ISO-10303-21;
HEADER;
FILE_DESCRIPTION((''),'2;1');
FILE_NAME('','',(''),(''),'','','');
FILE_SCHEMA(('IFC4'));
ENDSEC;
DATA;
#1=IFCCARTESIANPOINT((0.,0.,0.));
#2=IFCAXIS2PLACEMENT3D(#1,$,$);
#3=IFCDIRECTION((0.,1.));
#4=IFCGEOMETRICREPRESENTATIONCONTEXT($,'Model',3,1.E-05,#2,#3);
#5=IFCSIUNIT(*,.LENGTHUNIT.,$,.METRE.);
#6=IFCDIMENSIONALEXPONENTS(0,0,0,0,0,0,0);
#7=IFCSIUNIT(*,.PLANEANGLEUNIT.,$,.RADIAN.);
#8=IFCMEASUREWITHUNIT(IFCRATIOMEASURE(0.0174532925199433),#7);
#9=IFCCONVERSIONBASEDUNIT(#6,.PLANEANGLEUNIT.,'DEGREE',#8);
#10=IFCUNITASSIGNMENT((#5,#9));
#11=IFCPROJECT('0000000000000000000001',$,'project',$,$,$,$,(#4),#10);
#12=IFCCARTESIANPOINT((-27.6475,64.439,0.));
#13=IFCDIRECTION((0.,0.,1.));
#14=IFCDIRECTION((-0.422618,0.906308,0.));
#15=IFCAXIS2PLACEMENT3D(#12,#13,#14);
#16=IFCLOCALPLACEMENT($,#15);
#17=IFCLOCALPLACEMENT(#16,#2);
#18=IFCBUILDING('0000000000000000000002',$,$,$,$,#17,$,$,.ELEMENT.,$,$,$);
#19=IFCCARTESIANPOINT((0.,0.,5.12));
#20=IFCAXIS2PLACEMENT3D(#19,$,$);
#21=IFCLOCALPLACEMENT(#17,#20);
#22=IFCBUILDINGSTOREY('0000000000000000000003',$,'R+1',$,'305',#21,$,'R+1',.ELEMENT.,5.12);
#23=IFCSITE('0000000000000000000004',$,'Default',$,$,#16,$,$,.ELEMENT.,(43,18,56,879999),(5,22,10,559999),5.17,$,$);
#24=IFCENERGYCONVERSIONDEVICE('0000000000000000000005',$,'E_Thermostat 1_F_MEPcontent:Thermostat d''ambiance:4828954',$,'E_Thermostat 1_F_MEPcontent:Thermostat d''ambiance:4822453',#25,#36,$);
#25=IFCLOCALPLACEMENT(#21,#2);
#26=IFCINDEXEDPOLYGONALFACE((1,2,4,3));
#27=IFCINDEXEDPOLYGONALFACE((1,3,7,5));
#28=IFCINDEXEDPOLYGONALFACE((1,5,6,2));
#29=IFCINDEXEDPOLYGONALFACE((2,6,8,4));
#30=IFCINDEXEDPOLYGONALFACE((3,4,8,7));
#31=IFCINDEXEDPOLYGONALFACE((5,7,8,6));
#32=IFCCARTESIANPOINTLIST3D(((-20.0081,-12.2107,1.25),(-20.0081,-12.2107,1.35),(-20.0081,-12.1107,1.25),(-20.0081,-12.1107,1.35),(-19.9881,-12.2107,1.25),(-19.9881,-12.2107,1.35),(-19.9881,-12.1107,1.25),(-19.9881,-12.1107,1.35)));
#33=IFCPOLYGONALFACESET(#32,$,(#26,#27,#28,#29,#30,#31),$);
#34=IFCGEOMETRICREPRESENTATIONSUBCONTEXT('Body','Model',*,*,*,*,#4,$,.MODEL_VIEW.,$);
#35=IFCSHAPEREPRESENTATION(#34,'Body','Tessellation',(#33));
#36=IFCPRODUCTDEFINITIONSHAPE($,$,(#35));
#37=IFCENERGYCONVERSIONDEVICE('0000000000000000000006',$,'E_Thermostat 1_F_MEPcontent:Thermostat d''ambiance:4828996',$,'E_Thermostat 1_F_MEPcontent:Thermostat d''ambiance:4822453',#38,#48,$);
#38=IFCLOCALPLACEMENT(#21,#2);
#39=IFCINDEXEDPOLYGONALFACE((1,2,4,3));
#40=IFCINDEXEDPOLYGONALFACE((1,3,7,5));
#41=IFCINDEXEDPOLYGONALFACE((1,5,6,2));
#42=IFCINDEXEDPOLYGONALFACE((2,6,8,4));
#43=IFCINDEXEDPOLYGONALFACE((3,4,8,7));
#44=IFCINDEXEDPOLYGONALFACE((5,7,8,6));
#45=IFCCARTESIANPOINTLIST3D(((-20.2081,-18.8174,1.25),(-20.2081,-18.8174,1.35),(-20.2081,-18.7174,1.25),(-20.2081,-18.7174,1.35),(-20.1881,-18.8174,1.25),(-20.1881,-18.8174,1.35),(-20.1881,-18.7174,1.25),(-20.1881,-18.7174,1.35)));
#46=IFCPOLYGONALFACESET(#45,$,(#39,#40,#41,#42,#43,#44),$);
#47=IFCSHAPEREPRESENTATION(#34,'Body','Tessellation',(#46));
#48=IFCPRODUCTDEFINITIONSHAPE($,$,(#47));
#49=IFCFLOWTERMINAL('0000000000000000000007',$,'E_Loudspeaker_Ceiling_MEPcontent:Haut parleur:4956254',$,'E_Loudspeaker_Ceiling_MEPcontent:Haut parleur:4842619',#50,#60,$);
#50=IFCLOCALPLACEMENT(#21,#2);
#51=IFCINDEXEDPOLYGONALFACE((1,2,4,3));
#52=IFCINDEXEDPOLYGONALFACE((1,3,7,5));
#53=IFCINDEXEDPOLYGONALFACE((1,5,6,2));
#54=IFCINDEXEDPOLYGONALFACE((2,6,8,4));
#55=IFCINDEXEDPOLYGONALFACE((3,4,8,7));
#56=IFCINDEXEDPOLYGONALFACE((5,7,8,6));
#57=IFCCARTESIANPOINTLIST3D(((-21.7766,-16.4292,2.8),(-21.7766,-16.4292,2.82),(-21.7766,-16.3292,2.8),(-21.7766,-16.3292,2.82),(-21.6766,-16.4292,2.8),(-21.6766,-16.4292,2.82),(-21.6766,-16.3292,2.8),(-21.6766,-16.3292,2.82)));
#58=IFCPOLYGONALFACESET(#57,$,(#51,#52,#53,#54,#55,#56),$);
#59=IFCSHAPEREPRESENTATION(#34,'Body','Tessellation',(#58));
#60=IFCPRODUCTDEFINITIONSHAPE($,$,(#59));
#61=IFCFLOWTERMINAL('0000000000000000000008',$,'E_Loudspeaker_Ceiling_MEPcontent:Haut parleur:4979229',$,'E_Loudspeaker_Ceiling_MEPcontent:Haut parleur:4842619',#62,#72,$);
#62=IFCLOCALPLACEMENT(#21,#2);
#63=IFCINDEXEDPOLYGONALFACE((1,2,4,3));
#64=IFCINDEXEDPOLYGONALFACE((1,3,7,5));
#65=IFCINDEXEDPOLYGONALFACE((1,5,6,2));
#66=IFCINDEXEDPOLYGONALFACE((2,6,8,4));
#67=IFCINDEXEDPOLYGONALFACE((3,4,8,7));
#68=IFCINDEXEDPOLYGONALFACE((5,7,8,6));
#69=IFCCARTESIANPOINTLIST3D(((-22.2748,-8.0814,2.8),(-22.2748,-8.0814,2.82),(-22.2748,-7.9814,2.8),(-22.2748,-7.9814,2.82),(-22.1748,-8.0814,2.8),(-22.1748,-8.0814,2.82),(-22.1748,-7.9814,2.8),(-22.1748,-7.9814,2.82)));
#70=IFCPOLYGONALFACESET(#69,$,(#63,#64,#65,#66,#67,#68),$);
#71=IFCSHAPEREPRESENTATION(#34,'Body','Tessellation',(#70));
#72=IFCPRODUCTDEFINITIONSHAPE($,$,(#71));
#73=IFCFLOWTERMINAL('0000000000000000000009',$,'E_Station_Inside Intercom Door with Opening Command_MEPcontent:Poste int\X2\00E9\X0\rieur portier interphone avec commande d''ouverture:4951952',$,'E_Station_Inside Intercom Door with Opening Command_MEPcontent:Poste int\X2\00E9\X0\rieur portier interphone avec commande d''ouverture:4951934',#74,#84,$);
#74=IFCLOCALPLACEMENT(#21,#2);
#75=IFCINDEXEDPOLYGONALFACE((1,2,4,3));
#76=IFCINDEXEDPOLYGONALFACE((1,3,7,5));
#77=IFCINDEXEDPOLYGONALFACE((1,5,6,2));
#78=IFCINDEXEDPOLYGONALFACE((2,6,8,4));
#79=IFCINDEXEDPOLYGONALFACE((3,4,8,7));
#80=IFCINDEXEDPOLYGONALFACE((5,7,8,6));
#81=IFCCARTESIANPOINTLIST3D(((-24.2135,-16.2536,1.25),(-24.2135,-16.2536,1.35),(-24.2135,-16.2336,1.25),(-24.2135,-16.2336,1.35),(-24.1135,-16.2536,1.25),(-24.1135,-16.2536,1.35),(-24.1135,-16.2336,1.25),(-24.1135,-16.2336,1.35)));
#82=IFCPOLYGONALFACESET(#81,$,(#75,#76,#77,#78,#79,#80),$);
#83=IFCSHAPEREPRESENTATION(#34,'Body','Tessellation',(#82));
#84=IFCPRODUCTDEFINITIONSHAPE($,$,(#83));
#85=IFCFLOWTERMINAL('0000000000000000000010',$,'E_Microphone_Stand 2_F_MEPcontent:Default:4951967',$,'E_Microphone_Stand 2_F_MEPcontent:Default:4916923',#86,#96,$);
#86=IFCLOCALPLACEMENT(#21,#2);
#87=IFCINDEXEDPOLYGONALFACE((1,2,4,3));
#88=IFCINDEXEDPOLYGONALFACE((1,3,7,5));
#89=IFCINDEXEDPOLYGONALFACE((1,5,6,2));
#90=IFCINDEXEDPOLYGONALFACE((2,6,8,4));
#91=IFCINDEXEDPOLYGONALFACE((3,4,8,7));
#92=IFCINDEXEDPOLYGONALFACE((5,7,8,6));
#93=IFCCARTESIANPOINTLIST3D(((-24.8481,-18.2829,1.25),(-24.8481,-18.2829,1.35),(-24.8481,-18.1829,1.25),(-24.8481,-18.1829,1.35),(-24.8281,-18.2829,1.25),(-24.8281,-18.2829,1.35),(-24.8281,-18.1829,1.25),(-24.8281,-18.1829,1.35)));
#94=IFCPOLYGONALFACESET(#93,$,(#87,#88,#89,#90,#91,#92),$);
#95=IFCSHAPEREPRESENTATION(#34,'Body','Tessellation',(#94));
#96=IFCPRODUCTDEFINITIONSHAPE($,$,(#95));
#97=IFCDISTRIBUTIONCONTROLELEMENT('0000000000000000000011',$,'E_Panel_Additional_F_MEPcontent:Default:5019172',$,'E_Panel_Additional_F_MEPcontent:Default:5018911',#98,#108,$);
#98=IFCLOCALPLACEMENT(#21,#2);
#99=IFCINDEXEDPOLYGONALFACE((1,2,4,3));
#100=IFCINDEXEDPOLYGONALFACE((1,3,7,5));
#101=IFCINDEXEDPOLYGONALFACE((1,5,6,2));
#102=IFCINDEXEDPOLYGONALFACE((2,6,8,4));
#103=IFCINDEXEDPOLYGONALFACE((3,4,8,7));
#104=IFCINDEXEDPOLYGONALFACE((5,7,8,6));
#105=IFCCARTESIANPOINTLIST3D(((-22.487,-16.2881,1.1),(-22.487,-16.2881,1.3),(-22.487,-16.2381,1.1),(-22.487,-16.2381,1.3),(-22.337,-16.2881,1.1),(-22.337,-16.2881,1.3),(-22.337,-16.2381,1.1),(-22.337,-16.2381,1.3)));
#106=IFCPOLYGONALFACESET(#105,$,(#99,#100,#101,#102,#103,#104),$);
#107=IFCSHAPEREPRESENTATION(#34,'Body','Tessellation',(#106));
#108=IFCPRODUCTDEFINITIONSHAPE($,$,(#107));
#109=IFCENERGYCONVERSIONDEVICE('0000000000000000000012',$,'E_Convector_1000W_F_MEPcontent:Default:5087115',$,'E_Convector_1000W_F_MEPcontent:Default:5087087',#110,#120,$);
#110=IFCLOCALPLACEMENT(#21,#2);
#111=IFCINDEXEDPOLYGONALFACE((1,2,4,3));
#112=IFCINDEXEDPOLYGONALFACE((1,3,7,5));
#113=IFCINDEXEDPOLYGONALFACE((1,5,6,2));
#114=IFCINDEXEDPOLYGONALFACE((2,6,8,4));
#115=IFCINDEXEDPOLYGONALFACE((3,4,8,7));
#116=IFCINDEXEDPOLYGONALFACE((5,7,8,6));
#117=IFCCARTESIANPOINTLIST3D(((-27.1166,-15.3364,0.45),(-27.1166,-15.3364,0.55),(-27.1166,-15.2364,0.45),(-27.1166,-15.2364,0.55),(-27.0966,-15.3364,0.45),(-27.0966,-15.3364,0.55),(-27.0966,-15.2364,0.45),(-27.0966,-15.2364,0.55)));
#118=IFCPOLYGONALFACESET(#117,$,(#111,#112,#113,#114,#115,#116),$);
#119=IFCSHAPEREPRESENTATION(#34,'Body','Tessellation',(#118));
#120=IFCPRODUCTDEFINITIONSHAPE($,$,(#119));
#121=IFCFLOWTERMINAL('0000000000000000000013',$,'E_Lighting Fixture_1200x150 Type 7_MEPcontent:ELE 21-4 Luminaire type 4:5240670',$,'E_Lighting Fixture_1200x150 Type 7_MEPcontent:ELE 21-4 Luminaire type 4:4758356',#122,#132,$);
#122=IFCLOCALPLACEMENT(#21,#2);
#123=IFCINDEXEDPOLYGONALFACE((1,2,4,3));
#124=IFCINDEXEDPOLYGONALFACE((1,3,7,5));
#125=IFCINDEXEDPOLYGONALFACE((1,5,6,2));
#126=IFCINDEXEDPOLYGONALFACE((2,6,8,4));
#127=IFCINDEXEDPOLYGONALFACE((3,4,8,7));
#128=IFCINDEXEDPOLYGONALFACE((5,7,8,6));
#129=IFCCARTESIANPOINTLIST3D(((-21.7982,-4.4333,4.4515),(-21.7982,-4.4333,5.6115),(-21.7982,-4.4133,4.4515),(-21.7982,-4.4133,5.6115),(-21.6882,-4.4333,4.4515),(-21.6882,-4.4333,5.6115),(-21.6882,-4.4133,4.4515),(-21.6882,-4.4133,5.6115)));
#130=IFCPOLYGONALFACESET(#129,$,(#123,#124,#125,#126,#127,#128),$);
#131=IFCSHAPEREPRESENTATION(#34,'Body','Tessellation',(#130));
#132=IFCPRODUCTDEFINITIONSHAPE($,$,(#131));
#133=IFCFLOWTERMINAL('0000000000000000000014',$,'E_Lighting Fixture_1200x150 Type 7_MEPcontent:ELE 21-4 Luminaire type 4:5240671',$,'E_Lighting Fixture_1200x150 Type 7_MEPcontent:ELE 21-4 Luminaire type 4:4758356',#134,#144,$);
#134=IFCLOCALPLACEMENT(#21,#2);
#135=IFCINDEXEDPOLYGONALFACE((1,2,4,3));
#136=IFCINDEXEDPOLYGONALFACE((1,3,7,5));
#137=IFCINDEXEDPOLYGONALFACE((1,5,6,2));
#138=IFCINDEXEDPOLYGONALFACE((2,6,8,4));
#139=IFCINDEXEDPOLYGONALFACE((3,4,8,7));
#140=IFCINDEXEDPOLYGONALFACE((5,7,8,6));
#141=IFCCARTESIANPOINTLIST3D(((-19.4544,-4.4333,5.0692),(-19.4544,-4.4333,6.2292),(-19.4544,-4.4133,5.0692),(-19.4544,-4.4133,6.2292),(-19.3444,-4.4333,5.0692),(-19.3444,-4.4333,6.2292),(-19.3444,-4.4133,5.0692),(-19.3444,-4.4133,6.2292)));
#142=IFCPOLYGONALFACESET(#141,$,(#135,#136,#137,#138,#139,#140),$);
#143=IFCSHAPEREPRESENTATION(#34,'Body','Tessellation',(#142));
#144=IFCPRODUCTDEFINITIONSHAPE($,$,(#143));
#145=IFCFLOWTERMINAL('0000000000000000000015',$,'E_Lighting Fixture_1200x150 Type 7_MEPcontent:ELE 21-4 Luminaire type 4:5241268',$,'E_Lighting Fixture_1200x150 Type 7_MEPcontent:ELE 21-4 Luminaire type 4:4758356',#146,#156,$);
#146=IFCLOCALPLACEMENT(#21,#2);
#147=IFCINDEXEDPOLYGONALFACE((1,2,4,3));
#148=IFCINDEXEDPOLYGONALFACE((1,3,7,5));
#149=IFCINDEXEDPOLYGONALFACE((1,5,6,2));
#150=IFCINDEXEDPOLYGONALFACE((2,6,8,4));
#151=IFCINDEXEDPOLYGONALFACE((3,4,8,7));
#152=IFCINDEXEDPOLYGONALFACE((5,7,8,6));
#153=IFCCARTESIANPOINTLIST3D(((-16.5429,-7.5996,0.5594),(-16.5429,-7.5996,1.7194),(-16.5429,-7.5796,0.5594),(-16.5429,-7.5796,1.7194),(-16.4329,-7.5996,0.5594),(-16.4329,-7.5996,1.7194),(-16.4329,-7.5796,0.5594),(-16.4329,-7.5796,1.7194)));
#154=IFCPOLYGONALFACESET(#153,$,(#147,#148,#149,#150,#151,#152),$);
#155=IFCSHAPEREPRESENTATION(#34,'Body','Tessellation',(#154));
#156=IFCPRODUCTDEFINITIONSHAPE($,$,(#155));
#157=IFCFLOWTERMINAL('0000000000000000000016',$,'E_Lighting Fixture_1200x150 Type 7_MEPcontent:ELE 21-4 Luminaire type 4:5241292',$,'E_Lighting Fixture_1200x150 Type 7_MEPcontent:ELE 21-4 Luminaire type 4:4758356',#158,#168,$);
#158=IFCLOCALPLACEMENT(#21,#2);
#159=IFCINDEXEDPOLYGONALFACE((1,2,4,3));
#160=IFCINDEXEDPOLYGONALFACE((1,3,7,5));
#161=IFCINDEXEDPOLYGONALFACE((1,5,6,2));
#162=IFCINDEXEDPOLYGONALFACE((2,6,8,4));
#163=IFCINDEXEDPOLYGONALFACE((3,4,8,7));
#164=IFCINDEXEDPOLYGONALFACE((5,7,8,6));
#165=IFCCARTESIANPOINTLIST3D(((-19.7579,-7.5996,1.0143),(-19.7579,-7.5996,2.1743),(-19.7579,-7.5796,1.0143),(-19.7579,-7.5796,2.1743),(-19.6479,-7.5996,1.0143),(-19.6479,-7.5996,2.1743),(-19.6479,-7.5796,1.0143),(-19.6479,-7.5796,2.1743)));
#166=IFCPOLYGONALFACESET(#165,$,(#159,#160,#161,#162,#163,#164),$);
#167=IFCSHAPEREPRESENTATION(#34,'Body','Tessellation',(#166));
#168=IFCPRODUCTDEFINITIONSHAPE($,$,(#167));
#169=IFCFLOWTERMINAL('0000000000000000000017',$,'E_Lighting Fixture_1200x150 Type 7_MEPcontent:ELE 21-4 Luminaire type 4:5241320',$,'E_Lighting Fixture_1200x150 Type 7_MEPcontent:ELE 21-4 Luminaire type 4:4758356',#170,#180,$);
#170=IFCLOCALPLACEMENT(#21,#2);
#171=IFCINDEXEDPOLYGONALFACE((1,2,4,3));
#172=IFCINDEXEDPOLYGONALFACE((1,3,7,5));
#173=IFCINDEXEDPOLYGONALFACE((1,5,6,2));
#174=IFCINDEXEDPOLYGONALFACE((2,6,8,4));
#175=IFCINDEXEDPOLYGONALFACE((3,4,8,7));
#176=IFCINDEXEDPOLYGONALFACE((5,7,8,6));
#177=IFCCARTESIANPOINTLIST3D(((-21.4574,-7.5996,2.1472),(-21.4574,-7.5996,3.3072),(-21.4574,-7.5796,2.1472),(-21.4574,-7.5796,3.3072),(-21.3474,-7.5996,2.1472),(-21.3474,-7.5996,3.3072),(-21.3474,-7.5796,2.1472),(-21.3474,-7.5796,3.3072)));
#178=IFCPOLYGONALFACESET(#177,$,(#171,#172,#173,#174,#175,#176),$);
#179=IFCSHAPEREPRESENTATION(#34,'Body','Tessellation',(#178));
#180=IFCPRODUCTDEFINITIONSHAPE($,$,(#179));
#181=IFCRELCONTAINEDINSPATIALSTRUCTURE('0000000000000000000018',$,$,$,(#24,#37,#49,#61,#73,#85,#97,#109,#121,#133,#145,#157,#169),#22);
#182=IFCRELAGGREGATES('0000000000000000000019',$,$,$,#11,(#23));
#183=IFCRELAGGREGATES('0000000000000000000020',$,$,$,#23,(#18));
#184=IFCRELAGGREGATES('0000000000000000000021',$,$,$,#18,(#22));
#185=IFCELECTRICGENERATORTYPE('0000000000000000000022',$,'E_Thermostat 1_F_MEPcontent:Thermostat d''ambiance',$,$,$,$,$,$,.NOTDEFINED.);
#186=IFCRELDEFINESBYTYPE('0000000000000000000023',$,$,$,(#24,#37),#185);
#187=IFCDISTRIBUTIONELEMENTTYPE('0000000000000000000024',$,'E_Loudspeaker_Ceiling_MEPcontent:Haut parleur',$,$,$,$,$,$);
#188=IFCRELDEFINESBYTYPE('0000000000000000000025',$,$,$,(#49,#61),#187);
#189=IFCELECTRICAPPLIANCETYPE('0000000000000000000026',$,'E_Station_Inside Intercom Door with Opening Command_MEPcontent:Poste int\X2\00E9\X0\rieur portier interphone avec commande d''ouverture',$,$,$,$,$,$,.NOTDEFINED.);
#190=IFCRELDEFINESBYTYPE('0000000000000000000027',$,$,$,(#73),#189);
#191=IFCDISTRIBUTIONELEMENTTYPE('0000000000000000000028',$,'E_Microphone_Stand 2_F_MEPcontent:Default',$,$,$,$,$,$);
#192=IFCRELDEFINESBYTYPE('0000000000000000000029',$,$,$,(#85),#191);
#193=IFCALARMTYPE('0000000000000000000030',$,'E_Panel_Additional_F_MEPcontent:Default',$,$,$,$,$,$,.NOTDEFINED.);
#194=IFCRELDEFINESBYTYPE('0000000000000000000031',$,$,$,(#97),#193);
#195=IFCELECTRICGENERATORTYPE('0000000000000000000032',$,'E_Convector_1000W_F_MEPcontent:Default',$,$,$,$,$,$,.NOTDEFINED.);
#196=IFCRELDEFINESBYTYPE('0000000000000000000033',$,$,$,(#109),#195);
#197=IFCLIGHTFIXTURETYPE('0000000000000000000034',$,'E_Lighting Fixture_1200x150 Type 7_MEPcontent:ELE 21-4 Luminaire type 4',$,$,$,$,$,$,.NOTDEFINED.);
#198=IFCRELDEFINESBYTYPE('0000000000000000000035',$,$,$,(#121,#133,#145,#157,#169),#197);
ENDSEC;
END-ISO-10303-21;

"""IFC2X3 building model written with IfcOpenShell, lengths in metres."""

from ifc_helpers import new_model, entity, si_unit, converted_unit, direction, frame, frame_2d, origin, origin_2d_with_axis, place, context, subcontext, project, spatial, rectangle, extrude, source, transform, mapped, type_object, type_shapes, element, save


model = new_model("IFC2X3")

# Units and contexts
model_context = context("Model", 3, precision=1e-05, world=origin(), true_north=direction((0.0, 1.0)))
body_context = subcontext(model_context, "Body", "Model", "MODEL_VIEW")
ifc_project = project(units=[si_unit("LENGTHUNIT", "METRE"), converted_unit("PLANEANGLEUNIT", "DEGREE", entity("IfcRatioMeasure", 0.0174532925199433), si_unit("PLANEANGLEUNIT", "RADIAN"), dimensions=[0, 0, 0, 0, 0, 0, 0])], contexts=[model_context])

# Site, building, storey
site_placement = place(None, frame((-27.6475, 64.439, 0.0), z_axis=(0.0, 0.0, 1.0), x_axis=(-0.422618, 0.906308, 0.0)))
site = spatial("IfcSite", under=ifc_project, at=site_placement, Name="Default", CompositionType="ELEMENT", RefLatitude=(43, 18, 56, 879999), RefLongitude=(5, 22, 10, 559999), RefElevation=5.17)
building_placement = place(site_placement, origin())
building = spatial("IfcBuilding", under=site, at=building_placement, CompositionType="ELEMENT")
storey_placement = place(building_placement, frame((0.0, 0.0, 5.12)))
storey = spatial("IfcBuildingStorey", under=building, at=storey_placement, Name="R+1", ObjectType="305", LongName="R+1", CompositionType="ELEMENT", Elevation=5.12)

# Energy conversion devices
electric_generator_type_1 = type_object("IfcElectricGeneratorType", Name="E_Thermostat 1_F_MEPcontent:Thermostat d'ambiance", PredefinedType="NOTDEFINED")
shared_shape_1 = source(origin(), body_context, "Body", "SweptSolid", [
    extrude(rectangle(XDim=0.1, YDim=0.1, at=origin_2d_with_axis()), frame((0.0, 0.0, 0.0), z_axis=(0.0, 0.0, 1.0), x_axis=(0.0, 1.0, 0.0)), (0.0, 0.0, 1.0), 0.02),
])
type_shapes(electric_generator_type_1, [shared_shape_1])
for number, where, z_axis, x_axis, name in (
    (1, (-20.0081, -12.1607, 1.3), (1.0, 0.0, 0.0), (0.0, 1.0, 0.0), "E_Thermostat 1_F_MEPcontent:Thermostat d'ambiance:4828954"),
    (2, (-20.1881, -18.7674, 1.3), (-1.0, 0.0, 0.0), (0.0, -1.0, 0.0), "E_Thermostat 1_F_MEPcontent:Thermostat d'ambiance:4828996"),
):
    element("IfcEnergyConversionDevice", number, at=place(storey_placement, frame(where, z_axis=z_axis, x_axis=x_axis)), inside=storey, type_object=electric_generator_type_1, Name=name, ObjectType="E_Thermostat 1_F_MEPcontent:Thermostat d'ambiance:4822453", context=body_context, shape_type="MappedRepresentation", body=[
        mapped(shared_shape_1, transform((0.0, 0.0, 0.0), scale=1.0)),
    ])

# Flow terminals
distribution_element_type_1 = type_object("IfcDistributionElementType", Name="E_Loudspeaker_Ceiling_MEPcontent:Haut parleur")
shared_shape_2 = source(origin(), body_context, "Body", "SweptSolid", [
    extrude(rectangle(XDim=0.1, YDim=0.1, at=origin_2d_with_axis()), frame((0.0, 0.0, 0.0), z_axis=(0.0, 0.0, 1.0), x_axis=(0.0, -1.0, 0.0)), (0.0, 0.0, 1.0), 0.02),
])
type_shapes(distribution_element_type_1, [shared_shape_2])
for number, where, z_axis, x_axis, name in (
    (3, (-21.7266, -16.3792, 2.8), (0.0, 0.0, 1.0), (-1.0, 0.0, 0.0), "E_Loudspeaker_Ceiling_MEPcontent:Haut parleur:4956254"),
    (4, (-22.2248, -8.0314, 2.8), (0.0, 0.0, 1.0), (-1.0, 0.0, 0.0), "E_Loudspeaker_Ceiling_MEPcontent:Haut parleur:4979229"),
):
    element("IfcFlowTerminal", number, at=place(storey_placement, frame(where, z_axis=z_axis, x_axis=x_axis)), inside=storey, type_object=distribution_element_type_1, Name=name, ObjectType="E_Loudspeaker_Ceiling_MEPcontent:Haut parleur:4842619", context=body_context, shape_type="MappedRepresentation", body=[
        mapped(shared_shape_2, transform((0.0, 0.0, 0.0), scale=1.0)),
    ])
electric_appliance_type = type_object("IfcElectricApplianceType", Name="E_Station_Inside Intercom Door with Opening Command_MEPcontent:Poste intérieur portier interphone avec commande d'ouverture", PredefinedType="NOTDEFINED")
shared_shape_3 = source(origin(), body_context, "Body", "SweptSolid", [
    extrude(rectangle(XDim=0.02, YDim=0.1, at=frame_2d((0.0, 0.0), x_axis=(1.0, 0.0))), frame((0.0, 0.01, -0.05), z_axis=(0.0, 0.0, 1.0), x_axis=(0.0, -1.0, 0.0)), (0.0, 0.0, 1.0), 0.1),
])
type_shapes(electric_appliance_type, [shared_shape_3])
flow_terminal_1_placement = place(storey_placement, frame((-24.1635, -16.2336, 1.3), z_axis=(0.0, 0.0, 1.0), x_axis=(-1.0, 0.0, 0.0)))
element("IfcFlowTerminal", 5, at=flow_terminal_1_placement, inside=storey, type_object=electric_appliance_type, Name="E_Station_Inside Intercom Door with Opening Command_MEPcontent:Poste intérieur portier interphone avec commande d'ouverture:4951952", ObjectType="E_Station_Inside Intercom Door with Opening Command_MEPcontent:Poste intérieur portier interphone avec commande d'ouverture:4951934", context=body_context, shape_type="MappedRepresentation", body=[
    mapped(shared_shape_3, transform((0.0, 0.0, 0.0), scale=1.0)),
])
distribution_element_type_2 = type_object("IfcDistributionElementType", Name="E_Microphone_Stand 2_F_MEPcontent:Default")
shared_shape_4 = source(origin(), body_context, "Body", "SweptSolid", [
    extrude(rectangle(XDim=0.1, YDim=0.1, at=origin_2d_with_axis()), frame((0.0, 0.0, 0.0), z_axis=(0.0, 0.0, 1.0), x_axis=(0.0, 1.0, 0.0)), (0.0, 0.0, 1.0), 0.02),
])
type_shapes(distribution_element_type_2, [shared_shape_4])
flow_terminal_2_placement = place(storey_placement, frame((-24.8481, -18.2329, 1.3), z_axis=(1.0, 0.0, 0.0), x_axis=(0.0, 1.0, 0.0)))
element("IfcFlowTerminal", 6, at=flow_terminal_2_placement, inside=storey, type_object=distribution_element_type_2, Name="E_Microphone_Stand 2_F_MEPcontent:Default:4951967", ObjectType="E_Microphone_Stand 2_F_MEPcontent:Default:4916923", context=body_context, shape_type="MappedRepresentation", body=[
    mapped(shared_shape_4, transform((0.0, 0.0, 0.0), scale=1.0)),
])

# Distribution control element
alarm_type_1 = type_object("IfcAlarmType", Name="E_Panel_Additional_F_MEPcontent:Default", PredefinedType="NOTDEFINED")
shared_shape_5 = source(origin(), body_context, "Body", "SweptSolid", [
    extrude(rectangle(XDim=0.2, YDim=0.15, at=origin_2d_with_axis()), frame((0.0, -0.1, 0.0), z_axis=(0.0, 0.0, 1.0), x_axis=(0.0, 1.0, 0.0)), (0.0, 0.0, 1.0), 0.05),
])
type_shapes(alarm_type_1, [shared_shape_5])
distribution_control_element_1_placement = place(storey_placement, frame((-22.412, -16.2381, 1.3), z_axis=(0.0, -1.0, 0.0), x_axis=(1.0, 0.0, 0.0)))
element("IfcDistributionControlElement", 7, at=distribution_control_element_1_placement, inside=storey, type_object=alarm_type_1, Name="E_Panel_Additional_F_MEPcontent:Default:5019172", ObjectType="E_Panel_Additional_F_MEPcontent:Default:5018911", context=body_context, shape_type="MappedRepresentation", body=[
    mapped(shared_shape_5, transform((0.0, 0.0, 0.0), scale=1.0)),
])

# Energy conversion device
electric_generator_type_2 = type_object("IfcElectricGeneratorType", Name="E_Convector_1000W_F_MEPcontent:Default", PredefinedType="NOTDEFINED")
shared_shape_6 = source(origin(), body_context, "Body", "SweptSolid", [
    extrude(rectangle(XDim=0.1, YDim=0.1, at=origin_2d_with_axis()), frame((0.0, 0.0, 0.0), z_axis=(0.0, 0.0, 1.0), x_axis=(0.0, 1.0, 0.0)), (0.0, 0.0, 1.0), 0.02),
])
type_shapes(electric_generator_type_2, [shared_shape_6])
energy_conversion_device_1_placement = place(storey_placement, frame((-27.1166, -15.2864, 0.5), z_axis=(1.0, 0.0, 0.0), x_axis=(0.0, 1.0, 0.0)))
element("IfcEnergyConversionDevice", 8, at=energy_conversion_device_1_placement, inside=storey, type_object=electric_generator_type_2, Name="E_Convector_1000W_F_MEPcontent:Default:5087115", ObjectType="E_Convector_1000W_F_MEPcontent:Default:5087087", context=body_context, shape_type="MappedRepresentation", body=[
    mapped(shared_shape_6, transform((0.0, 0.0, 0.0), scale=1.0)),
])

# Flow terminals
light_fixture_type_1 = type_object("IfcLightFixtureType", Name="E_Lighting Fixture_1200x150 Type 7_MEPcontent:ELE 21-4 Luminaire type 4", PredefinedType="NOTDEFINED")
shared_shape_7 = source(origin(), body_context, "Body", "SweptSolid", [
    extrude(rectangle(XDim=0.02, YDim=0.11, at=frame_2d((0.0, 0.0), x_axis=(1.0, 0.0))), frame((0.0, 0.01, -0.58), z_axis=(0.0, 0.0, 1.0), x_axis=(0.0, -1.0, 0.0)), (0.0, 0.0, 1.0), 1.16),
])
type_shapes(light_fixture_type_1, [shared_shape_7])
for number, where, name in (
    (9, (-21.7432, -4.4333, 5.0315), "E_Lighting Fixture_1200x150 Type 7_MEPcontent:ELE 21-4 Luminaire type 4:5240670"),
    (10, (-19.3994, -4.4333, 5.6492), "E_Lighting Fixture_1200x150 Type 7_MEPcontent:ELE 21-4 Luminaire type 4:5240671"),
    (11, (-16.4879, -7.5996, 1.1394), "E_Lighting Fixture_1200x150 Type 7_MEPcontent:ELE 21-4 Luminaire type 4:5241268"),
    (12, (-19.7029, -7.5996, 1.5943), "E_Lighting Fixture_1200x150 Type 7_MEPcontent:ELE 21-4 Luminaire type 4:5241292"),
    (13, (-21.4024, -7.5996, 2.7272), "E_Lighting Fixture_1200x150 Type 7_MEPcontent:ELE 21-4 Luminaire type 4:5241320"),
):
    element("IfcFlowTerminal", number, at=place(storey_placement, frame(where)), inside=storey, type_object=light_fixture_type_1, Name=name, ObjectType="E_Lighting Fixture_1200x150 Type 7_MEPcontent:ELE 21-4 Luminaire type 4:4758356", context=body_context, shape_type="MappedRepresentation", body=[
        mapped(shared_shape_7, transform((0.0, 0.0, 0.0), scale=1.0)),
    ])

save(model, "model.ifc")
